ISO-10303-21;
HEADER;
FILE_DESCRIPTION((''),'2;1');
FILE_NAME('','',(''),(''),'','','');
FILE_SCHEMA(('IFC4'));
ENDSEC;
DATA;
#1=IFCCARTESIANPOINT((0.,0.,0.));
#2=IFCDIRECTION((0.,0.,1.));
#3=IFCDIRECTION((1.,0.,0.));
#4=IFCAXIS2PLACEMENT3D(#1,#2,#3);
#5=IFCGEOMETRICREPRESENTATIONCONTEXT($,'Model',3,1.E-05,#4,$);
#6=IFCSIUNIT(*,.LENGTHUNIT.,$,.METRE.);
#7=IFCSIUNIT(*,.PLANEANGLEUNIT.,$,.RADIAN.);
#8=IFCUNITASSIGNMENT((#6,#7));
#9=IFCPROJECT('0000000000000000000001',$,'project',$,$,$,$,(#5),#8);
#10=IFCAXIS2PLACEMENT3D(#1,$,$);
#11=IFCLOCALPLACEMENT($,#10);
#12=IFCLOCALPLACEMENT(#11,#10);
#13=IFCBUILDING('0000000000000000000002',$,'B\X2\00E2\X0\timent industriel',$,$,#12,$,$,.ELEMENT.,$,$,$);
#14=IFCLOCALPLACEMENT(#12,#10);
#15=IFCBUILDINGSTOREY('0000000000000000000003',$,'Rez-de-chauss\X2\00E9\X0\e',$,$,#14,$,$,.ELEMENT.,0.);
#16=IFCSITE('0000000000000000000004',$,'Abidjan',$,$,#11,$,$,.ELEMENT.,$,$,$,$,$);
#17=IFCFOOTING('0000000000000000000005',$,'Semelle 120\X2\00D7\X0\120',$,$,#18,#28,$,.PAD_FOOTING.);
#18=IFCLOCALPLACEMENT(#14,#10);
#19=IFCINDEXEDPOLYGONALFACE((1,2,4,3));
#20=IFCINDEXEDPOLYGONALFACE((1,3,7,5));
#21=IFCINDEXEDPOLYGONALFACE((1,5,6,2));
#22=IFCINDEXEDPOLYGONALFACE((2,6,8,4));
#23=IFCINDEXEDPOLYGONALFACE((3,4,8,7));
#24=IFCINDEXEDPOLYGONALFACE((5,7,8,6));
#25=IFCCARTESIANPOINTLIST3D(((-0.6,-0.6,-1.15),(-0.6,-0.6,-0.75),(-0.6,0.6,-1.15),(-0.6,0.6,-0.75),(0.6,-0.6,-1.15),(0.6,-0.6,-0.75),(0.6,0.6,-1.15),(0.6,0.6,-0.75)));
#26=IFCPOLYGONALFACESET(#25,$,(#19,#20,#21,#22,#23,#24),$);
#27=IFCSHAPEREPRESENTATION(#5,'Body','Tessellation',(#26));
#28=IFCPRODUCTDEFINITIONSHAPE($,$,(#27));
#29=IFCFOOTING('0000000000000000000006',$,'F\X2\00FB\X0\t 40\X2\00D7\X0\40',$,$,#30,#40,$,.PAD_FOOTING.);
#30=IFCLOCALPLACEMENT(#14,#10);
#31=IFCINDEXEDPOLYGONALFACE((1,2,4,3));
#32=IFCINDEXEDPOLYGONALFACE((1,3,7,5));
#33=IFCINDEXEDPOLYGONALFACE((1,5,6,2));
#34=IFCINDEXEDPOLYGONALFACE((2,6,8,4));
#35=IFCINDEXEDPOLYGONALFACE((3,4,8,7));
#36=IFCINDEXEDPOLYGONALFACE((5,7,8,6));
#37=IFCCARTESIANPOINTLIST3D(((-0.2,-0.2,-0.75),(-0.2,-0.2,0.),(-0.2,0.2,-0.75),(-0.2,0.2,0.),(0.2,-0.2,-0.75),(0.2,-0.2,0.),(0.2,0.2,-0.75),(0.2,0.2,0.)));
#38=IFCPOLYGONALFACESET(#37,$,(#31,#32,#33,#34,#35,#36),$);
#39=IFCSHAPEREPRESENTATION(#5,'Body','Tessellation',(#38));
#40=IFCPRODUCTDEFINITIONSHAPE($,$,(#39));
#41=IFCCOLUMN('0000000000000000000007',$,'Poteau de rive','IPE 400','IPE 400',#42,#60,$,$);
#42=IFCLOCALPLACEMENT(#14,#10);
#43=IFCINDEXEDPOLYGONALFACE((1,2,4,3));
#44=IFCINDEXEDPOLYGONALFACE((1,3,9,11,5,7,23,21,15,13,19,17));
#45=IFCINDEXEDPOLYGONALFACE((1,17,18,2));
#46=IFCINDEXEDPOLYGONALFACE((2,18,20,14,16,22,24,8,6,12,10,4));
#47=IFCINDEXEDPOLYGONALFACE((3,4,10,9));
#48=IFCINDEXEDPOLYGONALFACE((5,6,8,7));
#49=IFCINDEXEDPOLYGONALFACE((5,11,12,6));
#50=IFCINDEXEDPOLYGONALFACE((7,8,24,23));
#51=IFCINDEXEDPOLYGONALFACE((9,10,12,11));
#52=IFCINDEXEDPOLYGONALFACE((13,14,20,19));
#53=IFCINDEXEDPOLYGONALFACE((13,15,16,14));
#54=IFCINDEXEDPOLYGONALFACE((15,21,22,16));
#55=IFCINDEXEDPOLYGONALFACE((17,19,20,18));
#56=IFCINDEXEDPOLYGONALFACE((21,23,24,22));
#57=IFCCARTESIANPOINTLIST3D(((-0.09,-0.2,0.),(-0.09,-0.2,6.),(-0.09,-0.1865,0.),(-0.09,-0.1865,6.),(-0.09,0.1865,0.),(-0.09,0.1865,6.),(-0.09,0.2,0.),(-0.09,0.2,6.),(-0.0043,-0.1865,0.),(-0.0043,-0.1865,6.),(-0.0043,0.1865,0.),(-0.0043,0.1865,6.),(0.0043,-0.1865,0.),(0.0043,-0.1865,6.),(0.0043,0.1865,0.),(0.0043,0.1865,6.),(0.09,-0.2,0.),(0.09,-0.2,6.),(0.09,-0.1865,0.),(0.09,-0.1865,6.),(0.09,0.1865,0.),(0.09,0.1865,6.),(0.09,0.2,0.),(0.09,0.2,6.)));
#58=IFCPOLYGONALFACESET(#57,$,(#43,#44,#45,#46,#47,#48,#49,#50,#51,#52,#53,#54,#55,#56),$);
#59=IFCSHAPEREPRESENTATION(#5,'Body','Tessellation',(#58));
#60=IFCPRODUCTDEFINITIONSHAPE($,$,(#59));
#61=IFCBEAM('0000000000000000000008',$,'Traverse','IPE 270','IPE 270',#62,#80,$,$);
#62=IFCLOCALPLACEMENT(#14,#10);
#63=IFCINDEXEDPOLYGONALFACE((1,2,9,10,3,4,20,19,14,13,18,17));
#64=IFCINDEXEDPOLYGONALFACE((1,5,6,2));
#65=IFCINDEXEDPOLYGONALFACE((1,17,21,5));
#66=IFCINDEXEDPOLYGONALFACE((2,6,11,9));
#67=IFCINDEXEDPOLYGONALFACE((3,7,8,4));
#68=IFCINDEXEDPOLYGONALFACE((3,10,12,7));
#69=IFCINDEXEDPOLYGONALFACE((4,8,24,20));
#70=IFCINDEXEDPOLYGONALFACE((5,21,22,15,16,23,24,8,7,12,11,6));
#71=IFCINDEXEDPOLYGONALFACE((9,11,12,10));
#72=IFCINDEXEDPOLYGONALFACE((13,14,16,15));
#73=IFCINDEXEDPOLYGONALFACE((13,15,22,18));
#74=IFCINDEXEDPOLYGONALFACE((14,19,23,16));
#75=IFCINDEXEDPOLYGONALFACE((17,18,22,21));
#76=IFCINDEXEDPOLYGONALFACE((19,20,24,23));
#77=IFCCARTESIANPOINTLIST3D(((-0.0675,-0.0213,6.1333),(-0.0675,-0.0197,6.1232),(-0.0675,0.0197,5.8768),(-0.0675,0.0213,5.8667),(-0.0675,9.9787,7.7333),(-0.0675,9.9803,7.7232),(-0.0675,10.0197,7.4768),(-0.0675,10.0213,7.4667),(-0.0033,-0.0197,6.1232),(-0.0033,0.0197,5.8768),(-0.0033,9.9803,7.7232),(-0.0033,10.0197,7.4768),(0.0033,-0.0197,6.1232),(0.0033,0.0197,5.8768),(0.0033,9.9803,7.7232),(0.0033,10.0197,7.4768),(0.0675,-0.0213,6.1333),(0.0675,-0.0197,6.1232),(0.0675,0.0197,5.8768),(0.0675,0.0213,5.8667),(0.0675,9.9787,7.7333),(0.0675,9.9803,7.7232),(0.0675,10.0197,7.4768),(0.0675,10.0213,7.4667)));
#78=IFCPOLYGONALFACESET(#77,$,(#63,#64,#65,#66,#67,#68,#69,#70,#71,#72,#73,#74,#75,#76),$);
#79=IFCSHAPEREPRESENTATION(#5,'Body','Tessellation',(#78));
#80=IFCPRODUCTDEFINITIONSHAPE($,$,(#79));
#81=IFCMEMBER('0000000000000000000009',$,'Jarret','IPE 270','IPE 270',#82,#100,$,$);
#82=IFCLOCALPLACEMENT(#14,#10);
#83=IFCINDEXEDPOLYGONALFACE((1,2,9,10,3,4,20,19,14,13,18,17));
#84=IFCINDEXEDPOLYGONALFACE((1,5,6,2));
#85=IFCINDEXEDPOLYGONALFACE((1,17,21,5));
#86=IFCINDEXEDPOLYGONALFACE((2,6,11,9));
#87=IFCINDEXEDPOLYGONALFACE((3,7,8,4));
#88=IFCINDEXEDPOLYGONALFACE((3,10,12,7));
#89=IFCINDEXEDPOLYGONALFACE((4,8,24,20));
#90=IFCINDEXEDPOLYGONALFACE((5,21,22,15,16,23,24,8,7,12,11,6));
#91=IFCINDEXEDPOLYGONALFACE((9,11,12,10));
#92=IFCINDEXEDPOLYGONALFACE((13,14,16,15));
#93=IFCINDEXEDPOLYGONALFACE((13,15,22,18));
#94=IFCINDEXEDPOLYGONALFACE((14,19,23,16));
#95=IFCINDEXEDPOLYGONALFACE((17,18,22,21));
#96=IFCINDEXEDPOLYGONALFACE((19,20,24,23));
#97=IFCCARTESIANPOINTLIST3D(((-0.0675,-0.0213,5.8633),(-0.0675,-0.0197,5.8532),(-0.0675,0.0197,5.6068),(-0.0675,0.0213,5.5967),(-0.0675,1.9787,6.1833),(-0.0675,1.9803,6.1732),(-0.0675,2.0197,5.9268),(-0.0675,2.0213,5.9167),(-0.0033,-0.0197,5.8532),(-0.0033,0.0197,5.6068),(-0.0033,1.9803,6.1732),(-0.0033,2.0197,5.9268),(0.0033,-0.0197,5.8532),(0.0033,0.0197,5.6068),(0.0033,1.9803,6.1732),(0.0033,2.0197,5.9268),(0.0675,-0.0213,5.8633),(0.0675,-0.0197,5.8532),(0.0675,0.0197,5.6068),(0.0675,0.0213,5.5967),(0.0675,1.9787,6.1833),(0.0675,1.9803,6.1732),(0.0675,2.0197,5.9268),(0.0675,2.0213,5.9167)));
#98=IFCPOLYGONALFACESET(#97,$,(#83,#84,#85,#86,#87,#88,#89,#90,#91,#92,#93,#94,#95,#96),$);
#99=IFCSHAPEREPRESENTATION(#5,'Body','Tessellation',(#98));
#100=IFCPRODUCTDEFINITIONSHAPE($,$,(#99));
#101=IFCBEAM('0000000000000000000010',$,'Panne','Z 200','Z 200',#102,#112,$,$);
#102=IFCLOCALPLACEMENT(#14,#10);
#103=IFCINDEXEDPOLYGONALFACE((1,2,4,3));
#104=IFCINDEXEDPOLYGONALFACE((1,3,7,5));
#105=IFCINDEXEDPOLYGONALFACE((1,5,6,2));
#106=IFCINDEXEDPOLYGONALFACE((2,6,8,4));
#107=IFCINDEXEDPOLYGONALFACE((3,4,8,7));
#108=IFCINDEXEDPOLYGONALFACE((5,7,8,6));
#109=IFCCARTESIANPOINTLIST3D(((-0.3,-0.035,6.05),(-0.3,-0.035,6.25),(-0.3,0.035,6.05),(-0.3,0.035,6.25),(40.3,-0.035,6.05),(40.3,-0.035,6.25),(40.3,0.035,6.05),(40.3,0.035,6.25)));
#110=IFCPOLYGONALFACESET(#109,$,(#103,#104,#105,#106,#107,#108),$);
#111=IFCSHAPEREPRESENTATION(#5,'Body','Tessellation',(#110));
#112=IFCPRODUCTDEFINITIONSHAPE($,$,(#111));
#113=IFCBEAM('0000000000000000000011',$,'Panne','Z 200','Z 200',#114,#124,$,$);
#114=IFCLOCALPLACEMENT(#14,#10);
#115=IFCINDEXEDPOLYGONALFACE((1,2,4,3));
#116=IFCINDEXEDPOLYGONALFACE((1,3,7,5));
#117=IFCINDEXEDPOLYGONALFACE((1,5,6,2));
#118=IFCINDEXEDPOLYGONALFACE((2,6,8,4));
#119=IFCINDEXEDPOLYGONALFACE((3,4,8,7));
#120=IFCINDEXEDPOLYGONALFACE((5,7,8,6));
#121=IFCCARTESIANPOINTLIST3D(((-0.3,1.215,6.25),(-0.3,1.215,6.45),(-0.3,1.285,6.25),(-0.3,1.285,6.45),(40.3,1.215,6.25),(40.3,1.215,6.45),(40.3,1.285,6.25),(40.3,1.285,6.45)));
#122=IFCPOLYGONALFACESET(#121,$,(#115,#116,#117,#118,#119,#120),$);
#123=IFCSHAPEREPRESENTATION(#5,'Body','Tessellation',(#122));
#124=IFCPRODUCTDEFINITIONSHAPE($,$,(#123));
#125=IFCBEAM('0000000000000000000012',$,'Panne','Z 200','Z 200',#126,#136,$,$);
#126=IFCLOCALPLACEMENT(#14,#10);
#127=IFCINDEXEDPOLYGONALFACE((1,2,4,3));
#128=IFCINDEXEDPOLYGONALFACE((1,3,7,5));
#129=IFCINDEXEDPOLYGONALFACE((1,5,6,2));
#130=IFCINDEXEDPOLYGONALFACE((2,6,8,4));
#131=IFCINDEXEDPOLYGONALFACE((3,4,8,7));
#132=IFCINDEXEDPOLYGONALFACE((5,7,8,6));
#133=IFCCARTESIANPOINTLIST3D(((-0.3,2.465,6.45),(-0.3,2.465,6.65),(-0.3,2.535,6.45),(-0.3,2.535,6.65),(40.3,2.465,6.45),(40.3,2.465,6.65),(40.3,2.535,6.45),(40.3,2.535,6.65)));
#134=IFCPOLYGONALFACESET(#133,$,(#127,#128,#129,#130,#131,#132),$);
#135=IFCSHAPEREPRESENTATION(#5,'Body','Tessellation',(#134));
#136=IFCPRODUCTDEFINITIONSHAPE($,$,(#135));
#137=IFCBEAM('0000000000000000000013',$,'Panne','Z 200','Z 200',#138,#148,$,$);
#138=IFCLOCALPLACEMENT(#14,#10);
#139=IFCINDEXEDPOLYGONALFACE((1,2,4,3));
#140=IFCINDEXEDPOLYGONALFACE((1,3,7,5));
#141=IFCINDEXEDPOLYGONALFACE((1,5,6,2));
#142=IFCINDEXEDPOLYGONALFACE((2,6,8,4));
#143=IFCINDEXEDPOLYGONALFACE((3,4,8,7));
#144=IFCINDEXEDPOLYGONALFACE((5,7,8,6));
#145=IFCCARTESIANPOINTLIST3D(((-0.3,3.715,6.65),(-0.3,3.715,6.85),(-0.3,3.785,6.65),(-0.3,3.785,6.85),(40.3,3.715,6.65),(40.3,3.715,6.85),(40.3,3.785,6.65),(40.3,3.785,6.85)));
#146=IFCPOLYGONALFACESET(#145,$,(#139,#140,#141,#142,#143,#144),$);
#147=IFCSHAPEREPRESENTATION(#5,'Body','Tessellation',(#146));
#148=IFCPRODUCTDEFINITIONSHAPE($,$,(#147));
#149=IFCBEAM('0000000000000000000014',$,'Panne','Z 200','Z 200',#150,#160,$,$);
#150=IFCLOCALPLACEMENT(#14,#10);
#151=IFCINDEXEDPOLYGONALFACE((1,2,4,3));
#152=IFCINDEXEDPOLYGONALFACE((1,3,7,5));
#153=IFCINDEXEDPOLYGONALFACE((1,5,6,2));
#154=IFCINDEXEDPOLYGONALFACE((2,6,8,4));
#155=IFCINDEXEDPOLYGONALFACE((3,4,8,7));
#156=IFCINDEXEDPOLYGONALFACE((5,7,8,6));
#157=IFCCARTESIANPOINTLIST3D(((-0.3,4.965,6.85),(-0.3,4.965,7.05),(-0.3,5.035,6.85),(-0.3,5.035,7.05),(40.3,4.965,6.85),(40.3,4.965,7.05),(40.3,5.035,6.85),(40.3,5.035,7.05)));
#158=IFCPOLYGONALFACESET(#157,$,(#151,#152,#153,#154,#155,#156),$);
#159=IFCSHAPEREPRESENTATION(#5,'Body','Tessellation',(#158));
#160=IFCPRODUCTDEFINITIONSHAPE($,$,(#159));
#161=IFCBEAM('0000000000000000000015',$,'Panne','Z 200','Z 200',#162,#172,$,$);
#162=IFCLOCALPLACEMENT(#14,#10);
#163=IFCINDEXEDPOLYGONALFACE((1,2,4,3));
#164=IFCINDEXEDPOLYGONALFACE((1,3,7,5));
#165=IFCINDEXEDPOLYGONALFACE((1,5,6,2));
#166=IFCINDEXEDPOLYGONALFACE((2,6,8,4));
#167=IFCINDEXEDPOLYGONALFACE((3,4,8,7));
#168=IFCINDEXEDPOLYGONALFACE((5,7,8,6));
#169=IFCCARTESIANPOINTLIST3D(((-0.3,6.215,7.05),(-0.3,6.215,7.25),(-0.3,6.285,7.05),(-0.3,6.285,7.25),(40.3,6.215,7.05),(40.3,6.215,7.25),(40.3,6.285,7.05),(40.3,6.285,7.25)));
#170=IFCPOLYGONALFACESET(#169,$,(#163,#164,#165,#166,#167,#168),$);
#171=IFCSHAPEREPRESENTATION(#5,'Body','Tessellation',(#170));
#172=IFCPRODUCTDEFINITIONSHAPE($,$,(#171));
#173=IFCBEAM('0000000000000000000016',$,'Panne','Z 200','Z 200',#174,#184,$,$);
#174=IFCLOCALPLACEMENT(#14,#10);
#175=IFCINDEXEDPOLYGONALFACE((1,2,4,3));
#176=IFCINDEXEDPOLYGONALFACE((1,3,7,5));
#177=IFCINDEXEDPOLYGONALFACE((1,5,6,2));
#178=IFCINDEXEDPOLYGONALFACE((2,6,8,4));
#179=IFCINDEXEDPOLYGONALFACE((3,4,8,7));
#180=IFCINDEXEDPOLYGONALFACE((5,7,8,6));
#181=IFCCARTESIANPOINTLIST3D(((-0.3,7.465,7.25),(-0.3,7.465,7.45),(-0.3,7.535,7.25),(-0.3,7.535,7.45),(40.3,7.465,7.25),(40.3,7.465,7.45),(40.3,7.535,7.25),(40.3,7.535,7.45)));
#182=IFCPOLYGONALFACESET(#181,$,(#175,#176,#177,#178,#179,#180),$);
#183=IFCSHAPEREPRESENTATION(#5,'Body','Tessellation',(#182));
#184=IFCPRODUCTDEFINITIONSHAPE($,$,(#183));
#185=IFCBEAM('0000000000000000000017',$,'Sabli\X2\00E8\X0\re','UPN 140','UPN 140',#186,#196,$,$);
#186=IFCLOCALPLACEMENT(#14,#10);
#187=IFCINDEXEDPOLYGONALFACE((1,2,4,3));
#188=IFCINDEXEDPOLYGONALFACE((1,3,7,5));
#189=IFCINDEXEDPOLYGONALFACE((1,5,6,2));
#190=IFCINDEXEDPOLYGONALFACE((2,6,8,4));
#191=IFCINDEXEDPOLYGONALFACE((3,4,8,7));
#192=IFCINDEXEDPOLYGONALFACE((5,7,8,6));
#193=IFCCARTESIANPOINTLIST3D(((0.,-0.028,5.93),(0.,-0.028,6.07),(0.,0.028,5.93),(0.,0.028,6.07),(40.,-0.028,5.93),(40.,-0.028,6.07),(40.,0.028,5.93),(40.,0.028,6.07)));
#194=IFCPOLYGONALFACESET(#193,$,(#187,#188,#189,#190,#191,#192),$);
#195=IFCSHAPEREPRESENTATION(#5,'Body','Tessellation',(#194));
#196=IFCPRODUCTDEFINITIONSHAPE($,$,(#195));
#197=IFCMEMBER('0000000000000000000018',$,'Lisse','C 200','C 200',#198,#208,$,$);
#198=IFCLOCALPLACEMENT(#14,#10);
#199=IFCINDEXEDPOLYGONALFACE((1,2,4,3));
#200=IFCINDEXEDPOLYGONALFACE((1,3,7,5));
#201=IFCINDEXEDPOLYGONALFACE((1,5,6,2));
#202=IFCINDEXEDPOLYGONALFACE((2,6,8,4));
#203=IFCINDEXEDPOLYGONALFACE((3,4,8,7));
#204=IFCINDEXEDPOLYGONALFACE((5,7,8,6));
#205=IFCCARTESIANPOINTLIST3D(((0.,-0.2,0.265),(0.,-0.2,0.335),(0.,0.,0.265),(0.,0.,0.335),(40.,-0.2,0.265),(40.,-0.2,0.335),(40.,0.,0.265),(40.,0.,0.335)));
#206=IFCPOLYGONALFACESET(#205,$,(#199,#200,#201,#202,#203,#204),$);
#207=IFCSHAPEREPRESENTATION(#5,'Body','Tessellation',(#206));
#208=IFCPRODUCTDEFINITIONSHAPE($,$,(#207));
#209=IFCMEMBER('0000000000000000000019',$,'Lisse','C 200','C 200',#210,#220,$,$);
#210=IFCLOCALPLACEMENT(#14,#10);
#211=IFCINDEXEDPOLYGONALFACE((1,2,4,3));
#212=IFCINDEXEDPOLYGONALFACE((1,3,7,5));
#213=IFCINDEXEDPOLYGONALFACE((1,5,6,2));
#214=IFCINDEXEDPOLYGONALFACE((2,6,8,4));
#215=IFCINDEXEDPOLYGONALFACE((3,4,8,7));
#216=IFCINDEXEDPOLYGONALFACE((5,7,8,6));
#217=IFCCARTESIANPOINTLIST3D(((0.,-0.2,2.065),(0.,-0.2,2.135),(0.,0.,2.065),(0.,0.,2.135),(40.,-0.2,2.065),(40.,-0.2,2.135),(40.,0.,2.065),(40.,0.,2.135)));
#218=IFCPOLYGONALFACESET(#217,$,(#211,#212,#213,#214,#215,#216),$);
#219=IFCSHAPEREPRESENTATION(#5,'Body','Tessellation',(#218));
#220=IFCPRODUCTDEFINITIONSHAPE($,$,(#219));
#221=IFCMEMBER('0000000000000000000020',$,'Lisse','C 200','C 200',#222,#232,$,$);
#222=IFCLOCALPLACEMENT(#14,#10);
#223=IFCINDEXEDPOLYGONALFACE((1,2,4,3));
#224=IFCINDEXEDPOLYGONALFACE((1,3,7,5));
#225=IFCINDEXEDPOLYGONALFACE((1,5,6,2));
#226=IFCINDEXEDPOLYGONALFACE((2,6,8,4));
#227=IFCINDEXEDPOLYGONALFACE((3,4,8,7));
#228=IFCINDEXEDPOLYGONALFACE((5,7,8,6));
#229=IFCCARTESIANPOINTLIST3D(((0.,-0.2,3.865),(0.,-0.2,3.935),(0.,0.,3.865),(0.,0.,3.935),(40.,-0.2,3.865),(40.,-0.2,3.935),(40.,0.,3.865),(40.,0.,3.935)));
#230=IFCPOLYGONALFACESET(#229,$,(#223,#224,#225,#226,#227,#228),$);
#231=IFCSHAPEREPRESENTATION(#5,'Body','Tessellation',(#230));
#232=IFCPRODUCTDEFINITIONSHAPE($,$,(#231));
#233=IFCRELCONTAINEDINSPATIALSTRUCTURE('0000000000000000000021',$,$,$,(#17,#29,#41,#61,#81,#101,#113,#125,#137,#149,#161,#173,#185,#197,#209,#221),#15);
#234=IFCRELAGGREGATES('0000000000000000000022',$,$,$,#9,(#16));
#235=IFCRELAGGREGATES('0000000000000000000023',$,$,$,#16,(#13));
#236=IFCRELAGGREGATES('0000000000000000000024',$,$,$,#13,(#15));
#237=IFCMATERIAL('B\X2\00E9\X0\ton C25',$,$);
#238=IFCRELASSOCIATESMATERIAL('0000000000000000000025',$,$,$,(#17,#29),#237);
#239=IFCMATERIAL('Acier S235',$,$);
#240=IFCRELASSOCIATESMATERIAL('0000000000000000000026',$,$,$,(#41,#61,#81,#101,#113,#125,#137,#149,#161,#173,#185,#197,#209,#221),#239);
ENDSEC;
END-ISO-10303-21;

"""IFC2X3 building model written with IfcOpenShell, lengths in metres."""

from ifc_helpers import new_model, si_unit, frame, origin, origin_with_axes, origin_2d, place, context, project, spatial, rectangle, i_section, extrude, material, element, save


model = new_model("IFC2X3")

# Units and contexts
model_context = context("Model", 3, precision=1e-05, world=origin_with_axes())
ifc_project = project(units=[si_unit("LENGTHUNIT", "METRE"), si_unit("PLANEANGLEUNIT", "RADIAN")], contexts=[model_context])

# Site, building, storey
site_placement = place(None, origin())
site = spatial("IfcSite", under=ifc_project, at=site_placement, Name="Abidjan", CompositionType="ELEMENT")
building_placement = place(site_placement, origin())
building = spatial("IfcBuilding", under=site, at=building_placement, Name="Bâtiment industriel", CompositionType="ELEMENT")
storey_placement = place(building_placement, origin())
storey = spatial("IfcBuildingStorey", under=building, at=storey_placement, Name="Rez-de-chaussée", CompositionType="ELEMENT", Elevation=0.0)

# Footings
ifc_material_1 = material(Name="Béton C25")
footing_1_placement = place(storey_placement, frame((0.0, 0.0, -1.15), z_axis=(0.0, 0.0, 1.0), x_axis=(1.0, 0.0, 0.0)))
element("IfcFooting", 1, at=footing_1_placement, inside=storey, material=ifc_material_1, Name="Semelle 120×120", PredefinedType="PAD_FOOTING", context=model_context, shape_type="SweptSolid", body=[
    extrude(rectangle(XDim=1.2, YDim=1.2, at=origin_2d()), origin(), (0.0, 0.0, 1.0), 0.4),
])
footing_2_placement = place(storey_placement, frame((0.0, 0.0, -0.75), z_axis=(0.0, 0.0, 1.0), x_axis=(1.0, 0.0, 0.0)))
element("IfcFooting", 2, at=footing_2_placement, inside=storey, material=ifc_material_1, Name="Fût 40×40", PredefinedType="PAD_FOOTING", context=model_context, shape_type="SweptSolid", body=[
    extrude(rectangle(XDim=0.4, YDim=0.4, at=origin_2d()), origin(), (0.0, 0.0, 1.0), 0.75),
])

# Column
ifc_material_2 = material(Name="Acier S235")
column_placement = place(storey_placement, origin_with_axes())
element("IfcColumn", 3, at=column_placement, inside=storey, material=ifc_material_2, Name="Poteau de rive", Description="IPE 400", ObjectType="IPE 400", context=model_context, shape_type="SweptSolid", body=[
    extrude(i_section(OverallWidth=0.18, OverallDepth=0.4, WebThickness=0.0086, FlangeThickness=0.0135, at=origin_2d()), origin(), (0.0, 0.0, 1.0), 6.0),
])

# Beam
beam_1_placement = place(storey_placement, frame((0.0, 0.0, 6.0), z_axis=(0.0, 0.98744, 0.15799), x_axis=(1.0, 0.0, 0.0)))
element("IfcBeam", 4, at=beam_1_placement, inside=storey, material=ifc_material_2, Name="Traverse", Description="IPE 270", ObjectType="IPE 270", context=model_context, shape_type="SweptSolid", body=[
    extrude(i_section(OverallWidth=0.135, OverallDepth=0.27, WebThickness=0.0066, FlangeThickness=0.0102, at=origin_2d()), origin(), (0.0, 0.0, 1.0), 10.1272),
])

# Member
member_placement = place(storey_placement, frame((0.0, 0.0, 5.73), z_axis=(0.0, 0.98744, 0.15799), x_axis=(1.0, 0.0, 0.0)))
element("IfcMember", 5, at=member_placement, inside=storey, material=ifc_material_2, Name="Jarret", Description="IPE 270", ObjectType="IPE 270", context=model_context, shape_type="SweptSolid", body=[
    extrude(i_section(OverallWidth=0.135, OverallDepth=0.27, WebThickness=0.0066, FlangeThickness=0.0102, at=origin_2d()), origin(), (0.0, 0.0, 1.0), 2.0254),
])

# Beams
for number, where, z_axis, x_axis, name in (
    (6, (-0.3, 0.0, 6.15), (1.0, 0.0, 0.0), (0.0, 1.0, 0.0), "Panne"),
    (7, (-0.3, 1.25, 6.35), (1.0, 0.0, 0.0), (0.0, 1.0, 0.0), "Panne"),
    (8, (-0.3, 2.5, 6.55), (1.0, 0.0, 0.0), (0.0, 1.0, 0.0), "Panne"),
    (9, (-0.3, 3.75, 6.75), (1.0, 0.0, 0.0), (0.0, 1.0, 0.0), "Panne"),
    (10, (-0.3, 5.0, 6.95), (1.0, 0.0, 0.0), (0.0, 1.0, 0.0), "Panne"),
    (11, (-0.3, 6.25, 7.15), (1.0, 0.0, 0.0), (0.0, 1.0, 0.0), "Panne"),
    (12, (-0.3, 7.5, 7.35), (1.0, 0.0, 0.0), (0.0, 1.0, 0.0), "Panne"),
):
    element("IfcBeam", number, at=place(storey_placement, frame(where, z_axis=z_axis, x_axis=x_axis)), inside=storey, material=ifc_material_2, Name=name, Description="Z 200", ObjectType="Z 200", context=model_context, shape_type="SweptSolid", body=[
        extrude(rectangle(XDim=0.07, YDim=0.2, at=origin_2d()), origin(), (0.0, 0.0, 1.0), 40.6),
    ])
beam_2_placement = place(storey_placement, frame((0.0, 0.0, 6.0), z_axis=(1.0, 0.0, 0.0), x_axis=(0.0, 1.0, 0.0)))
element("IfcBeam", 13, at=beam_2_placement, inside=storey, material=ifc_material_2, Name="Sablière", Description="UPN 140", ObjectType="UPN 140", context=model_context, shape_type="SweptSolid", body=[
    extrude(rectangle(XDim=0.056, YDim=0.14, at=origin_2d()), origin(), (0.0, 0.0, 1.0), 40.0),
])

# Members
for number, where, z_axis, x_axis, name in (
    (14, (0.0, -0.1, 0.3), (1.0, 0.0, 0.0), (0.0, 0.0, 1.0), "Lisse"),
    (15, (0.0, -0.1, 2.1), (1.0, 0.0, 0.0), (0.0, 0.0, 1.0), "Lisse"),
    (16, (0.0, -0.1, 3.9), (1.0, 0.0, 0.0), (0.0, 0.0, 1.0), "Lisse"),
):
    element("IfcMember", number, at=place(storey_placement, frame(where, z_axis=z_axis, x_axis=x_axis)), inside=storey, material=ifc_material_2, Name=name, Description="C 200", ObjectType="C 200", context=model_context, shape_type="SweptSolid", body=[
        extrude(rectangle(XDim=0.07, YDim=0.2, at=origin_2d()), origin(), (0.0, 0.0, 1.0), 40.0),
    ])

save(model, "model.ifc")
